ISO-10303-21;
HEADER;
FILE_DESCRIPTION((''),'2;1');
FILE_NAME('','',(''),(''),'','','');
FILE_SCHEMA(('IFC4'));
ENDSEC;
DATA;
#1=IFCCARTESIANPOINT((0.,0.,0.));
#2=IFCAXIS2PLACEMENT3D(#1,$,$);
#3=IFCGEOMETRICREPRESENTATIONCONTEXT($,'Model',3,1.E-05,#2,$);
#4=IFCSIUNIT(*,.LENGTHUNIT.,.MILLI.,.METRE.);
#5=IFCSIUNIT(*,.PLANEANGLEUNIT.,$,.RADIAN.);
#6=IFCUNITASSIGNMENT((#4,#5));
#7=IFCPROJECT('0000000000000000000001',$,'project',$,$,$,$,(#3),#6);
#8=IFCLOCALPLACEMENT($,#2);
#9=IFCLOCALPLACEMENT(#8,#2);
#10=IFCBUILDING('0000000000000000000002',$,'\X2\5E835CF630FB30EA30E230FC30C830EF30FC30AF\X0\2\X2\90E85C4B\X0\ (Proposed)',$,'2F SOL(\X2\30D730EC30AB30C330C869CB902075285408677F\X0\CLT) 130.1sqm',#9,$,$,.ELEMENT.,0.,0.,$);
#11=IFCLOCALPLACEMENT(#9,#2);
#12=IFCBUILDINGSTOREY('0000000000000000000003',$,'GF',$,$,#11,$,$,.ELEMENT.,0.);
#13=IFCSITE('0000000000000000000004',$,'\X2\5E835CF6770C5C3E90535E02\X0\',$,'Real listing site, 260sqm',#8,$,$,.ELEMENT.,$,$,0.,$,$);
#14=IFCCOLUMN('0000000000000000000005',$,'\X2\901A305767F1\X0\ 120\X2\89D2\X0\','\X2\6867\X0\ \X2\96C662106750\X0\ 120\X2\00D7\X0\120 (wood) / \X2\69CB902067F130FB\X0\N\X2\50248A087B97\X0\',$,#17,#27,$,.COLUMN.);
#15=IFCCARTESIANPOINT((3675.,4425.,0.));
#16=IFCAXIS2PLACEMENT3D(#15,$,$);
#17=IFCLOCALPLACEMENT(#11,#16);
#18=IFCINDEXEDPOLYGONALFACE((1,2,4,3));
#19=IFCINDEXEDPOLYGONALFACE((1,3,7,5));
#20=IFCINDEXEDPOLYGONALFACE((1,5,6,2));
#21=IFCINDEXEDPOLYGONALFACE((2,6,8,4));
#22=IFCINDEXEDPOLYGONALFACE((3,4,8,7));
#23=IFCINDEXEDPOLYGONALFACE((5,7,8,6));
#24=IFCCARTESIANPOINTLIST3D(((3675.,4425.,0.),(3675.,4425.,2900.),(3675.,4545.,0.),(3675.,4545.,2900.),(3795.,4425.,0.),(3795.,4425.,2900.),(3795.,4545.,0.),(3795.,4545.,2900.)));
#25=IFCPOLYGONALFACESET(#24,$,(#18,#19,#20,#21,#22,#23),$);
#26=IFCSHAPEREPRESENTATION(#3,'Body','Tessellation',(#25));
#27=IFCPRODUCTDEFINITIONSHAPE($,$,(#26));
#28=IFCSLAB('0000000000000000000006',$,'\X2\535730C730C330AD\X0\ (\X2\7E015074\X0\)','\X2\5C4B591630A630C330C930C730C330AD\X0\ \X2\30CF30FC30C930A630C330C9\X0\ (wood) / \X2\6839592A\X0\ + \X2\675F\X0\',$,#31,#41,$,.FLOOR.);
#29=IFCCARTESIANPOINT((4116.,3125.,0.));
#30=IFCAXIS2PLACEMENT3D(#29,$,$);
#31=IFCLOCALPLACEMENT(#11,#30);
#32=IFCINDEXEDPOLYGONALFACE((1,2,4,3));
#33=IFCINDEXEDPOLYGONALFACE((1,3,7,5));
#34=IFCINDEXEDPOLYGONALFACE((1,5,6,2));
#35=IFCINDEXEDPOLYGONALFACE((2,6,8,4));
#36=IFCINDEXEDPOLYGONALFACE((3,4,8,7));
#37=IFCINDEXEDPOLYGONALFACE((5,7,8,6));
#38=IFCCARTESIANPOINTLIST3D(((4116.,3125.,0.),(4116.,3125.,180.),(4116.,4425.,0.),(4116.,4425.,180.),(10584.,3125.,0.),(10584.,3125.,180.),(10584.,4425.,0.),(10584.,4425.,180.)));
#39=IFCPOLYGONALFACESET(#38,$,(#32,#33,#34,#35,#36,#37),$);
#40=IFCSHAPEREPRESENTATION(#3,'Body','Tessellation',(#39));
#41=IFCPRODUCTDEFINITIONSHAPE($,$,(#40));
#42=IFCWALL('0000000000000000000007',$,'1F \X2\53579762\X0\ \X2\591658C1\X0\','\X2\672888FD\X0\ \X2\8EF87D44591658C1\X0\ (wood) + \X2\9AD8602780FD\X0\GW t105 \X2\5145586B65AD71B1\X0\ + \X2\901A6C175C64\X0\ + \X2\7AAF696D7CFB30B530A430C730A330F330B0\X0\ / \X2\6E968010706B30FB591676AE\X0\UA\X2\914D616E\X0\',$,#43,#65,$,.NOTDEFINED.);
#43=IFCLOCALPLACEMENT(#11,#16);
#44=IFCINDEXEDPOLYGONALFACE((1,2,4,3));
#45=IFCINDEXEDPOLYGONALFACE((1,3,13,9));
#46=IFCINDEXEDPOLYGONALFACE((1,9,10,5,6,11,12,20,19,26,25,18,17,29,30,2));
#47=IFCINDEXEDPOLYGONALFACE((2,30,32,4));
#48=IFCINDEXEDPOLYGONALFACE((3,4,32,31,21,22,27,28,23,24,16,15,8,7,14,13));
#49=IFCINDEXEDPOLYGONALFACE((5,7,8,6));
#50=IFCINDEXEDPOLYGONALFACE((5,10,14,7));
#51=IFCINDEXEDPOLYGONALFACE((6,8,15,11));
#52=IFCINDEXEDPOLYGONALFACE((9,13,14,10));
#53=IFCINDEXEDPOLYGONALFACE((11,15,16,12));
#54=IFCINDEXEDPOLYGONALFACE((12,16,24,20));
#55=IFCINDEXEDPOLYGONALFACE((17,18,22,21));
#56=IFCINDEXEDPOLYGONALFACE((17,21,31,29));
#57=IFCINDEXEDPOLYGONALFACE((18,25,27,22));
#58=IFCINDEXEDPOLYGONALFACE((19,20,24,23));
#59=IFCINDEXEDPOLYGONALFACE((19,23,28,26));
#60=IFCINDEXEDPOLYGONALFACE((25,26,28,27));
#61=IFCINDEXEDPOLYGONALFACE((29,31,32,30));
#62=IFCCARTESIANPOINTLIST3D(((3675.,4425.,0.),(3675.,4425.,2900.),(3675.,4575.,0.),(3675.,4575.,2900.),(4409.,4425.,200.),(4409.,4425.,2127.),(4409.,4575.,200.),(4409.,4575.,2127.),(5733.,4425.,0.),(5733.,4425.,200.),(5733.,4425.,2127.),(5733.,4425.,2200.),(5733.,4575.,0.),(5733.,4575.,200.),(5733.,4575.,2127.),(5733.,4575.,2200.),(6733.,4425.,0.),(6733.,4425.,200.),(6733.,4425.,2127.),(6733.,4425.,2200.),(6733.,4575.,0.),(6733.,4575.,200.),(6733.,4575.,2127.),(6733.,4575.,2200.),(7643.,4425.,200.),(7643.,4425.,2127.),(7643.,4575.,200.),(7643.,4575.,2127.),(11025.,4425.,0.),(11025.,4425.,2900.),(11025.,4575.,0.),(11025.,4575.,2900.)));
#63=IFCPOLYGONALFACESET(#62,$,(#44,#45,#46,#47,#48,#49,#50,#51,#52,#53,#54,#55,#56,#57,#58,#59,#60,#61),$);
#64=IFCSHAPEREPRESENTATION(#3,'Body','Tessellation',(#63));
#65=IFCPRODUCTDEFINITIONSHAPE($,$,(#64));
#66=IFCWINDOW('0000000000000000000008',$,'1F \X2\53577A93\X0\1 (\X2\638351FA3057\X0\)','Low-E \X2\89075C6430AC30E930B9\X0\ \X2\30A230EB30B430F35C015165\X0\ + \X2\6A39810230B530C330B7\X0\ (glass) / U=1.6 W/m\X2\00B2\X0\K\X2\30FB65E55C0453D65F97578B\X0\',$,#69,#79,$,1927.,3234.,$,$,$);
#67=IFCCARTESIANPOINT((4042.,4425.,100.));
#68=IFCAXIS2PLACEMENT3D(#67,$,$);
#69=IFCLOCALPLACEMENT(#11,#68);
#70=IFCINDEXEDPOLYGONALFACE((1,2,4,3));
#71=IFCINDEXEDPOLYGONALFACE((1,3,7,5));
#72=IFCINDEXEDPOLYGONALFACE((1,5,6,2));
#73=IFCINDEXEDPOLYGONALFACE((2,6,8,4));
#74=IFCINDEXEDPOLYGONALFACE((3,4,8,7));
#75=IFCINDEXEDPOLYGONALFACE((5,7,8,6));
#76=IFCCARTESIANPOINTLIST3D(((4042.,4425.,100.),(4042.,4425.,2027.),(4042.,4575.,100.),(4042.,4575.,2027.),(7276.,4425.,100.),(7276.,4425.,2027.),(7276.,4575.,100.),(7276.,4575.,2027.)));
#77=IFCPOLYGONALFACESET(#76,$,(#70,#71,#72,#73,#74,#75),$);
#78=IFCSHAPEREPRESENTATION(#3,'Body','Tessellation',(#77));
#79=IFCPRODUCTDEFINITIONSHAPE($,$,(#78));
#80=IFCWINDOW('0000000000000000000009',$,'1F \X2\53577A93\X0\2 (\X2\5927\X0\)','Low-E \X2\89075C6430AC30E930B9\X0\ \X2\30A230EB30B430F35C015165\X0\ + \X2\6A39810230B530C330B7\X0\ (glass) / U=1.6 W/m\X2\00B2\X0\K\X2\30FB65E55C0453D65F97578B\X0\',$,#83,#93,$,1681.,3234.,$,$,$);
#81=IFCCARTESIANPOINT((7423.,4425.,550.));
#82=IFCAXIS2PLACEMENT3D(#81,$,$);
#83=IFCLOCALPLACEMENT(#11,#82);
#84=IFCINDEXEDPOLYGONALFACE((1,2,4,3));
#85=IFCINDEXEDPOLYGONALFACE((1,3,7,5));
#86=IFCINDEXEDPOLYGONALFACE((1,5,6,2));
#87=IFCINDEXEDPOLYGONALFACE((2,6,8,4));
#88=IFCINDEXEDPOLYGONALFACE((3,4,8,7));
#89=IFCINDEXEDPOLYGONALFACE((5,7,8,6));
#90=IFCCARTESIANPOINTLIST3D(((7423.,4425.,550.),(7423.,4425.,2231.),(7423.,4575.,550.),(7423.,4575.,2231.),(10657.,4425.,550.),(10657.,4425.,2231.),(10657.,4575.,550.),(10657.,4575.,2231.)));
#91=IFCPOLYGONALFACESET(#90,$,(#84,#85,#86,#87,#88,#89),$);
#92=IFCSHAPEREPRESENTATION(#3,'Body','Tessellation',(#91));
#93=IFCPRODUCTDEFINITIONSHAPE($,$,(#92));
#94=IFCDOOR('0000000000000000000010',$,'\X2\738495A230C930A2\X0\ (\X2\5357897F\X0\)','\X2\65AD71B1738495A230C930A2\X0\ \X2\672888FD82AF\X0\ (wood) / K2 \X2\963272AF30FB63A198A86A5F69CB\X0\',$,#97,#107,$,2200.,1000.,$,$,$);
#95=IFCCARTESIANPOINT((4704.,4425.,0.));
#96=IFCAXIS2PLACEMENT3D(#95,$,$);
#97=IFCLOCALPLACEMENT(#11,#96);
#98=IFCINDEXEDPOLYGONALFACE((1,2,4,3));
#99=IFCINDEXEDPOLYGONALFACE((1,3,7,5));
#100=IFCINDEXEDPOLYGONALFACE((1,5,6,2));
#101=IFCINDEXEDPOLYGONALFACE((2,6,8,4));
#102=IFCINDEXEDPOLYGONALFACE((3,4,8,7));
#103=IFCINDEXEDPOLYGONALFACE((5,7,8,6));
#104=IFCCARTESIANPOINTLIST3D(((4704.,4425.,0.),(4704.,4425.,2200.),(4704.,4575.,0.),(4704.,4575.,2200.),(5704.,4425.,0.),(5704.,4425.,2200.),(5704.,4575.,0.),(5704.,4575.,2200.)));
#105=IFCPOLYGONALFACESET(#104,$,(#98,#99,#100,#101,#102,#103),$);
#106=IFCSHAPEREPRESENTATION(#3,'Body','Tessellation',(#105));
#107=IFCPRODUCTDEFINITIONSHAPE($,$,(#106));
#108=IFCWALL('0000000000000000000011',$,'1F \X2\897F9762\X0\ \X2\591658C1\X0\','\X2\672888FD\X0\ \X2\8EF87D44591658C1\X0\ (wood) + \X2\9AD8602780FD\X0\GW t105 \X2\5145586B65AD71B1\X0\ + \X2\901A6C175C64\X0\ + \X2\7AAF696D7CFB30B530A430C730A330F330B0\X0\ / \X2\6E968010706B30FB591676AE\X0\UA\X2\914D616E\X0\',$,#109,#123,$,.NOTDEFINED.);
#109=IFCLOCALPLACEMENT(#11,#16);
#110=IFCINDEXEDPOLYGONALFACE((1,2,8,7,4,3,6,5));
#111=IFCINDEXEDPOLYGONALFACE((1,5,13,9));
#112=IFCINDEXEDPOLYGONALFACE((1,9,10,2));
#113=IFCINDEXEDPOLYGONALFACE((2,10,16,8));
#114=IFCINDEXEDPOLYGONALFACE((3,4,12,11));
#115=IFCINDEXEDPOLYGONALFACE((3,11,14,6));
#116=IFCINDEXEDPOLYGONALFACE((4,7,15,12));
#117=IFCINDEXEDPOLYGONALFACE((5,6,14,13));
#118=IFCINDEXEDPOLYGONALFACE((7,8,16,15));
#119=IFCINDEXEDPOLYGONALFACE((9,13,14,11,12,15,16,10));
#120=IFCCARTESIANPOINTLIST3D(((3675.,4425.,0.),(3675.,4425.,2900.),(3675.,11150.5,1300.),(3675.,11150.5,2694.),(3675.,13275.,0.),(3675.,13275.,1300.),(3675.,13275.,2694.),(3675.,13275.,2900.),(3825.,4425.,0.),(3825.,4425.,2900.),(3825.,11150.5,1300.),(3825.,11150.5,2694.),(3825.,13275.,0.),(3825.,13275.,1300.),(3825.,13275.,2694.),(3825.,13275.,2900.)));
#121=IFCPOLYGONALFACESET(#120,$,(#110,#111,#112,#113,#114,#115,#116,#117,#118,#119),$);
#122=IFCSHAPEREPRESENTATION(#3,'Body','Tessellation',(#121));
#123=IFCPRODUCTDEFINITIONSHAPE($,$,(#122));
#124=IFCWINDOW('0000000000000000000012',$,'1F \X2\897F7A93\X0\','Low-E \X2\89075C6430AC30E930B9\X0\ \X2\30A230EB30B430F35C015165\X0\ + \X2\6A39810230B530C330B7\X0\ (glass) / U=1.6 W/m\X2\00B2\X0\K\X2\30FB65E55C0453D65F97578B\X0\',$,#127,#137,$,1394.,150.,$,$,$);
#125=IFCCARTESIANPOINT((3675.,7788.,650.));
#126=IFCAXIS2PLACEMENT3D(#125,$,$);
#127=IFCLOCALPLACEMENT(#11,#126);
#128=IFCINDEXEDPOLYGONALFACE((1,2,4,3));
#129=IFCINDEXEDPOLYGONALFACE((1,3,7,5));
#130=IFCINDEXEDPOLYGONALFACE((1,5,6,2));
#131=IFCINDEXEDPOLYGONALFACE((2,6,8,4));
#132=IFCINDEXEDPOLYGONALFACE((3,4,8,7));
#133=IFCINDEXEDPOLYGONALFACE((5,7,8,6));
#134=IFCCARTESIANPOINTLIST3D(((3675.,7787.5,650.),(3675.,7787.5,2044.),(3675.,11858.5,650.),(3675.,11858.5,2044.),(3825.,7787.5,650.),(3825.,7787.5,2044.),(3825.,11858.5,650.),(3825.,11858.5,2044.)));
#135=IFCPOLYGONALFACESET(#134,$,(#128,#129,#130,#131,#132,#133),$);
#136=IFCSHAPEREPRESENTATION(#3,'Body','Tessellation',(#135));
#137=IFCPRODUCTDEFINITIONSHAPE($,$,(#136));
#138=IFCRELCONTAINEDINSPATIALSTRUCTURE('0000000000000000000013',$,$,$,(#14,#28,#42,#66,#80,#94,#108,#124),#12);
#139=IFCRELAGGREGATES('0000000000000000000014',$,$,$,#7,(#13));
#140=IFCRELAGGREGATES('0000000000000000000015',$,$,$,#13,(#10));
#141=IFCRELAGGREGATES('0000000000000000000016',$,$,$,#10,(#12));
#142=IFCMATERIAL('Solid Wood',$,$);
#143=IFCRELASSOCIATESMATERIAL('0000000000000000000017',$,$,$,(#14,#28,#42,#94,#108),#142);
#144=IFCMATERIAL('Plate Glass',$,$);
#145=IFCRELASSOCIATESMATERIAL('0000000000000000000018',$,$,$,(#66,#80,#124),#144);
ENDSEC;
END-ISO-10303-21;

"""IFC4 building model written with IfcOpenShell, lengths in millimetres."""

from ifc_helpers import new_model, si_unit, frame, frame_2d, origin, place, context, project, spatial, rectangle, extrude, material, element, fill, save


model = new_model("IFC4")

# Units and contexts
model_context = context("Model", 3, precision=1e-05, world=origin())
ifc_project = project(units=[si_unit("LENGTHUNIT", "METRE", prefix="MILLI"), si_unit("PLANEANGLEUNIT", "RADIAN")], contexts=[model_context])

# Site, building, storey
site_placement = place(None, origin())
site = spatial("IfcSite", under=ifc_project, at=site_placement, Name="広島県尾道市", ObjectType="Real listing site, 260sqm", CompositionType="ELEMENT", RefElevation=0.0)
building_placement = place(site_placement, origin())
building = spatial("IfcBuilding", under=site, at=building_placement, Name="広島・リモートワーク2部屋 (Proposed)", ObjectType="2F SOL(プレカット構造用合板CLT) 130.1sqm", CompositionType="ELEMENT", ElevationOfRefHeight=0.0, ElevationOfTerrain=0.0)
storey_placement = place(building_placement, origin())
storey = spatial("IfcBuildingStorey", under=building, at=storey_placement, Name="GF", CompositionType="ELEMENT", Elevation=0.0)

# Column
ifc_material_1 = material(Name="Solid Wood")
column_placement = place(storey_placement, frame((3675.0, 4425.0, 0.0)))
element("IfcColumn", 1, at=column_placement, inside=storey, material=ifc_material_1, Name="通し柱 120角", Description="桧 集成材 120×120 (wood) / 構造柱・N値計算", PredefinedType="COLUMN", context=model_context, shape_type="SweptSolid", body=[
    extrude(rectangle(XDim=120.0, YDim=120.0, at=frame_2d((60.0, 60.0))), frame((3675.0, 4425.0, 0.0)), (0.0, 0.0, 1.0), 2900.0),
])

# Slab
slab_1_placement = place(storey_placement, frame((4116.0, 3125.0, 0.0)))
element("IfcSlab", 2, at=slab_1_placement, inside=storey, material=ifc_material_1, Name="南デッキ (縁側)", Description="屋外ウッドデッキ ハードウッド (wood) / 根太 + 束", PredefinedType="FLOOR", context=model_context, shape_type="SweptSolid", body=[
    extrude(rectangle(XDim=6468.0, YDim=1300.0, at=frame_2d((3234.0, 650.0))), frame((4116.0, 3125.0, 0.0)), (0.0, 0.0, 1.0), 180.0),
])

# Wall, openings, windows, door
wall_1_placement = place(storey_placement, frame((3675.0, 4425.0, 0.0)))
wall_1 = element("IfcWall", 3, at=wall_1_placement, inside=storey, material=ifc_material_1, Name="1F 南面 外壁", Description="木製 軸組外壁 (wood) + 高性能GW t105 充填断熱 + 通気層 + 窯業系サイディング / 準耐火・外皮UA配慮", PredefinedType="NOTDEFINED", context=model_context, shape_type="SweptSolid", body=[
    extrude(rectangle(XDim=7350.0, YDim=150.0, at=frame_2d((3675.0, 75.0))), frame((3675.0, 4425.0, 0.0)), (0.0, 0.0, 1.0), 2900.0),
])
opening_1_placement = place(storey_placement, frame((4042.0, 4425.0, 100.0)))
opening_1 = element("IfcOpeningElement", 4, at=opening_1_placement, cuts=wall_1, PredefinedType="NOTDEFINED", context=model_context, shape_type="SweptSolid", body=[
    extrude(rectangle(XDim=3234.0, YDim=150.0, at=frame_2d((1617.0, 75.0))), frame((4042.0, 4425.0, 100.0)), (0.0, 0.0, 1.0), 1927.0),
])
opening_2_placement = place(storey_placement, frame((7423.0, 4425.0, 550.0)))
opening_2 = element("IfcOpeningElement", 5, at=opening_2_placement, cuts=wall_1, PredefinedType="NOTDEFINED", context=model_context, shape_type="SweptSolid", body=[
    extrude(rectangle(XDim=3234.0, YDim=150.0, at=frame_2d((1617.0, 75.0))), frame((7423.0, 4425.0, 550.0)), (0.0, 0.0, 1.0), 1681.0),
])
opening_3_placement = place(storey_placement, frame((4704.0, 4425.0, 0.0)))
opening_3 = element("IfcOpeningElement", 6, at=opening_3_placement, cuts=wall_1, PredefinedType="NOTDEFINED", context=model_context, shape_type="SweptSolid", body=[
    extrude(rectangle(XDim=1000.0, YDim=150.0, at=frame_2d((500.0, 75.0))), frame((4704.0, 4425.0, 0.0)), (0.0, 0.0, 1.0), 2200.0),
])
ifc_material_2 = material(Name="Plate Glass")
window_1_placement = place(storey_placement, frame((4042.0, 4425.0, 100.0)))
window_1 = element("IfcWindow", 7, at=window_1_placement, inside=storey, material=ifc_material_2, Name="1F 南窓1 (掃出し)", Description="Low-E 複層ガラス アルゴン封入 + 樹脂サッシ (glass) / U=1.6 W/m²K・日射取得型", OverallHeight=1927.0, OverallWidth=3234.0, context=model_context, shape_type="SweptSolid", body=[
    extrude(rectangle(XDim=3234.0, YDim=150.0, at=frame_2d((1617.0, 75.0))), frame((4042.0, 4425.0, 100.0)), (0.0, 0.0, 1.0), 1927.0),
])
fill(opening_1, window_1)
window_2_placement = place(storey_placement, frame((7423.0, 4425.0, 550.0)))
window_2 = element("IfcWindow", 8, at=window_2_placement, inside=storey, material=ifc_material_2, Name="1F 南窓2 (大)", Description="Low-E 複層ガラス アルゴン封入 + 樹脂サッシ (glass) / U=1.6 W/m²K・日射取得型", OverallHeight=1681.0, OverallWidth=3234.0, context=model_context, shape_type="SweptSolid", body=[
    extrude(rectangle(XDim=3234.0, YDim=150.0, at=frame_2d((1617.0, 75.0))), frame((7423.0, 4425.0, 550.0)), (0.0, 0.0, 1.0), 1681.0),
])
fill(opening_2, window_2)
door_placement = place(storey_placement, frame((4704.0, 4425.0, 0.0)))
door = element("IfcDoor", 9, at=door_placement, inside=storey, material=ifc_material_1, Name="玄関ドア (南西)", Description="断熱玄関ドア 木製芯 (wood) / K2 防犯・採風機構", OverallHeight=2200.0, OverallWidth=1000.0, context=model_context, shape_type="SweptSolid", body=[
    extrude(rectangle(XDim=1000.0, YDim=150.0, at=frame_2d((500.0, 75.0))), frame((4704.0, 4425.0, 0.0)), (0.0, 0.0, 1.0), 2200.0),
])
fill(opening_3, door)

# Wall, opening, window
wall_2_placement = place(storey_placement, frame((3675.0, 4425.0, 0.0)))
wall_2 = element("IfcWall", 10, at=wall_2_placement, inside=storey, material=ifc_material_1, Name="1F 西面 外壁", Description="木製 軸組外壁 (wood) + 高性能GW t105 充填断熱 + 通気層 + 窯業系サイディング / 準耐火・外皮UA配慮", PredefinedType="NOTDEFINED", context=model_context, shape_type="SweptSolid", body=[
    extrude(rectangle(XDim=150.0, YDim=8850.0, at=frame_2d((75.0, 4425.0))), frame((3675.0, 4425.0, 0.0)), (0.0, 0.0, 1.0), 2900.0),
])
opening_4_placement = place(storey_placement, frame((3675.0, 7788.0, 650.0)))
opening_4 = element("IfcOpeningElement", 11, at=opening_4_placement, cuts=wall_2, PredefinedType="NOTDEFINED", context=model_context, shape_type="SweptSolid", body=[
    extrude(rectangle(XDim=150.0, YDim=4071.0, at=frame_2d((75.0, 2035.0))), frame((3675.0, 7788.0, 650.0)), (0.0, 0.0, 1.0), 1394.0),
])
window_3_placement = place(storey_placement, frame((3675.0, 7788.0, 650.0)))
window_3 = element("IfcWindow", 12, at=window_3_placement, inside=storey, material=ifc_material_2, Name="1F 西窓", Description="Low-E 複層ガラス アルゴン封入 + 樹脂サッシ (glass) / U=1.6 W/m²K・日射取得型", OverallHeight=1394.0, OverallWidth=150.0, context=model_context, shape_type="SweptSolid", body=[
    extrude(rectangle(XDim=150.0, YDim=4071.0, at=frame_2d((75.0, 2035.0))), frame((3675.0, 7788.0, 650.0)), (0.0, 0.0, 1.0), 1394.0),
])
fill(opening_4, window_3)

save(model, "model.ifc")
